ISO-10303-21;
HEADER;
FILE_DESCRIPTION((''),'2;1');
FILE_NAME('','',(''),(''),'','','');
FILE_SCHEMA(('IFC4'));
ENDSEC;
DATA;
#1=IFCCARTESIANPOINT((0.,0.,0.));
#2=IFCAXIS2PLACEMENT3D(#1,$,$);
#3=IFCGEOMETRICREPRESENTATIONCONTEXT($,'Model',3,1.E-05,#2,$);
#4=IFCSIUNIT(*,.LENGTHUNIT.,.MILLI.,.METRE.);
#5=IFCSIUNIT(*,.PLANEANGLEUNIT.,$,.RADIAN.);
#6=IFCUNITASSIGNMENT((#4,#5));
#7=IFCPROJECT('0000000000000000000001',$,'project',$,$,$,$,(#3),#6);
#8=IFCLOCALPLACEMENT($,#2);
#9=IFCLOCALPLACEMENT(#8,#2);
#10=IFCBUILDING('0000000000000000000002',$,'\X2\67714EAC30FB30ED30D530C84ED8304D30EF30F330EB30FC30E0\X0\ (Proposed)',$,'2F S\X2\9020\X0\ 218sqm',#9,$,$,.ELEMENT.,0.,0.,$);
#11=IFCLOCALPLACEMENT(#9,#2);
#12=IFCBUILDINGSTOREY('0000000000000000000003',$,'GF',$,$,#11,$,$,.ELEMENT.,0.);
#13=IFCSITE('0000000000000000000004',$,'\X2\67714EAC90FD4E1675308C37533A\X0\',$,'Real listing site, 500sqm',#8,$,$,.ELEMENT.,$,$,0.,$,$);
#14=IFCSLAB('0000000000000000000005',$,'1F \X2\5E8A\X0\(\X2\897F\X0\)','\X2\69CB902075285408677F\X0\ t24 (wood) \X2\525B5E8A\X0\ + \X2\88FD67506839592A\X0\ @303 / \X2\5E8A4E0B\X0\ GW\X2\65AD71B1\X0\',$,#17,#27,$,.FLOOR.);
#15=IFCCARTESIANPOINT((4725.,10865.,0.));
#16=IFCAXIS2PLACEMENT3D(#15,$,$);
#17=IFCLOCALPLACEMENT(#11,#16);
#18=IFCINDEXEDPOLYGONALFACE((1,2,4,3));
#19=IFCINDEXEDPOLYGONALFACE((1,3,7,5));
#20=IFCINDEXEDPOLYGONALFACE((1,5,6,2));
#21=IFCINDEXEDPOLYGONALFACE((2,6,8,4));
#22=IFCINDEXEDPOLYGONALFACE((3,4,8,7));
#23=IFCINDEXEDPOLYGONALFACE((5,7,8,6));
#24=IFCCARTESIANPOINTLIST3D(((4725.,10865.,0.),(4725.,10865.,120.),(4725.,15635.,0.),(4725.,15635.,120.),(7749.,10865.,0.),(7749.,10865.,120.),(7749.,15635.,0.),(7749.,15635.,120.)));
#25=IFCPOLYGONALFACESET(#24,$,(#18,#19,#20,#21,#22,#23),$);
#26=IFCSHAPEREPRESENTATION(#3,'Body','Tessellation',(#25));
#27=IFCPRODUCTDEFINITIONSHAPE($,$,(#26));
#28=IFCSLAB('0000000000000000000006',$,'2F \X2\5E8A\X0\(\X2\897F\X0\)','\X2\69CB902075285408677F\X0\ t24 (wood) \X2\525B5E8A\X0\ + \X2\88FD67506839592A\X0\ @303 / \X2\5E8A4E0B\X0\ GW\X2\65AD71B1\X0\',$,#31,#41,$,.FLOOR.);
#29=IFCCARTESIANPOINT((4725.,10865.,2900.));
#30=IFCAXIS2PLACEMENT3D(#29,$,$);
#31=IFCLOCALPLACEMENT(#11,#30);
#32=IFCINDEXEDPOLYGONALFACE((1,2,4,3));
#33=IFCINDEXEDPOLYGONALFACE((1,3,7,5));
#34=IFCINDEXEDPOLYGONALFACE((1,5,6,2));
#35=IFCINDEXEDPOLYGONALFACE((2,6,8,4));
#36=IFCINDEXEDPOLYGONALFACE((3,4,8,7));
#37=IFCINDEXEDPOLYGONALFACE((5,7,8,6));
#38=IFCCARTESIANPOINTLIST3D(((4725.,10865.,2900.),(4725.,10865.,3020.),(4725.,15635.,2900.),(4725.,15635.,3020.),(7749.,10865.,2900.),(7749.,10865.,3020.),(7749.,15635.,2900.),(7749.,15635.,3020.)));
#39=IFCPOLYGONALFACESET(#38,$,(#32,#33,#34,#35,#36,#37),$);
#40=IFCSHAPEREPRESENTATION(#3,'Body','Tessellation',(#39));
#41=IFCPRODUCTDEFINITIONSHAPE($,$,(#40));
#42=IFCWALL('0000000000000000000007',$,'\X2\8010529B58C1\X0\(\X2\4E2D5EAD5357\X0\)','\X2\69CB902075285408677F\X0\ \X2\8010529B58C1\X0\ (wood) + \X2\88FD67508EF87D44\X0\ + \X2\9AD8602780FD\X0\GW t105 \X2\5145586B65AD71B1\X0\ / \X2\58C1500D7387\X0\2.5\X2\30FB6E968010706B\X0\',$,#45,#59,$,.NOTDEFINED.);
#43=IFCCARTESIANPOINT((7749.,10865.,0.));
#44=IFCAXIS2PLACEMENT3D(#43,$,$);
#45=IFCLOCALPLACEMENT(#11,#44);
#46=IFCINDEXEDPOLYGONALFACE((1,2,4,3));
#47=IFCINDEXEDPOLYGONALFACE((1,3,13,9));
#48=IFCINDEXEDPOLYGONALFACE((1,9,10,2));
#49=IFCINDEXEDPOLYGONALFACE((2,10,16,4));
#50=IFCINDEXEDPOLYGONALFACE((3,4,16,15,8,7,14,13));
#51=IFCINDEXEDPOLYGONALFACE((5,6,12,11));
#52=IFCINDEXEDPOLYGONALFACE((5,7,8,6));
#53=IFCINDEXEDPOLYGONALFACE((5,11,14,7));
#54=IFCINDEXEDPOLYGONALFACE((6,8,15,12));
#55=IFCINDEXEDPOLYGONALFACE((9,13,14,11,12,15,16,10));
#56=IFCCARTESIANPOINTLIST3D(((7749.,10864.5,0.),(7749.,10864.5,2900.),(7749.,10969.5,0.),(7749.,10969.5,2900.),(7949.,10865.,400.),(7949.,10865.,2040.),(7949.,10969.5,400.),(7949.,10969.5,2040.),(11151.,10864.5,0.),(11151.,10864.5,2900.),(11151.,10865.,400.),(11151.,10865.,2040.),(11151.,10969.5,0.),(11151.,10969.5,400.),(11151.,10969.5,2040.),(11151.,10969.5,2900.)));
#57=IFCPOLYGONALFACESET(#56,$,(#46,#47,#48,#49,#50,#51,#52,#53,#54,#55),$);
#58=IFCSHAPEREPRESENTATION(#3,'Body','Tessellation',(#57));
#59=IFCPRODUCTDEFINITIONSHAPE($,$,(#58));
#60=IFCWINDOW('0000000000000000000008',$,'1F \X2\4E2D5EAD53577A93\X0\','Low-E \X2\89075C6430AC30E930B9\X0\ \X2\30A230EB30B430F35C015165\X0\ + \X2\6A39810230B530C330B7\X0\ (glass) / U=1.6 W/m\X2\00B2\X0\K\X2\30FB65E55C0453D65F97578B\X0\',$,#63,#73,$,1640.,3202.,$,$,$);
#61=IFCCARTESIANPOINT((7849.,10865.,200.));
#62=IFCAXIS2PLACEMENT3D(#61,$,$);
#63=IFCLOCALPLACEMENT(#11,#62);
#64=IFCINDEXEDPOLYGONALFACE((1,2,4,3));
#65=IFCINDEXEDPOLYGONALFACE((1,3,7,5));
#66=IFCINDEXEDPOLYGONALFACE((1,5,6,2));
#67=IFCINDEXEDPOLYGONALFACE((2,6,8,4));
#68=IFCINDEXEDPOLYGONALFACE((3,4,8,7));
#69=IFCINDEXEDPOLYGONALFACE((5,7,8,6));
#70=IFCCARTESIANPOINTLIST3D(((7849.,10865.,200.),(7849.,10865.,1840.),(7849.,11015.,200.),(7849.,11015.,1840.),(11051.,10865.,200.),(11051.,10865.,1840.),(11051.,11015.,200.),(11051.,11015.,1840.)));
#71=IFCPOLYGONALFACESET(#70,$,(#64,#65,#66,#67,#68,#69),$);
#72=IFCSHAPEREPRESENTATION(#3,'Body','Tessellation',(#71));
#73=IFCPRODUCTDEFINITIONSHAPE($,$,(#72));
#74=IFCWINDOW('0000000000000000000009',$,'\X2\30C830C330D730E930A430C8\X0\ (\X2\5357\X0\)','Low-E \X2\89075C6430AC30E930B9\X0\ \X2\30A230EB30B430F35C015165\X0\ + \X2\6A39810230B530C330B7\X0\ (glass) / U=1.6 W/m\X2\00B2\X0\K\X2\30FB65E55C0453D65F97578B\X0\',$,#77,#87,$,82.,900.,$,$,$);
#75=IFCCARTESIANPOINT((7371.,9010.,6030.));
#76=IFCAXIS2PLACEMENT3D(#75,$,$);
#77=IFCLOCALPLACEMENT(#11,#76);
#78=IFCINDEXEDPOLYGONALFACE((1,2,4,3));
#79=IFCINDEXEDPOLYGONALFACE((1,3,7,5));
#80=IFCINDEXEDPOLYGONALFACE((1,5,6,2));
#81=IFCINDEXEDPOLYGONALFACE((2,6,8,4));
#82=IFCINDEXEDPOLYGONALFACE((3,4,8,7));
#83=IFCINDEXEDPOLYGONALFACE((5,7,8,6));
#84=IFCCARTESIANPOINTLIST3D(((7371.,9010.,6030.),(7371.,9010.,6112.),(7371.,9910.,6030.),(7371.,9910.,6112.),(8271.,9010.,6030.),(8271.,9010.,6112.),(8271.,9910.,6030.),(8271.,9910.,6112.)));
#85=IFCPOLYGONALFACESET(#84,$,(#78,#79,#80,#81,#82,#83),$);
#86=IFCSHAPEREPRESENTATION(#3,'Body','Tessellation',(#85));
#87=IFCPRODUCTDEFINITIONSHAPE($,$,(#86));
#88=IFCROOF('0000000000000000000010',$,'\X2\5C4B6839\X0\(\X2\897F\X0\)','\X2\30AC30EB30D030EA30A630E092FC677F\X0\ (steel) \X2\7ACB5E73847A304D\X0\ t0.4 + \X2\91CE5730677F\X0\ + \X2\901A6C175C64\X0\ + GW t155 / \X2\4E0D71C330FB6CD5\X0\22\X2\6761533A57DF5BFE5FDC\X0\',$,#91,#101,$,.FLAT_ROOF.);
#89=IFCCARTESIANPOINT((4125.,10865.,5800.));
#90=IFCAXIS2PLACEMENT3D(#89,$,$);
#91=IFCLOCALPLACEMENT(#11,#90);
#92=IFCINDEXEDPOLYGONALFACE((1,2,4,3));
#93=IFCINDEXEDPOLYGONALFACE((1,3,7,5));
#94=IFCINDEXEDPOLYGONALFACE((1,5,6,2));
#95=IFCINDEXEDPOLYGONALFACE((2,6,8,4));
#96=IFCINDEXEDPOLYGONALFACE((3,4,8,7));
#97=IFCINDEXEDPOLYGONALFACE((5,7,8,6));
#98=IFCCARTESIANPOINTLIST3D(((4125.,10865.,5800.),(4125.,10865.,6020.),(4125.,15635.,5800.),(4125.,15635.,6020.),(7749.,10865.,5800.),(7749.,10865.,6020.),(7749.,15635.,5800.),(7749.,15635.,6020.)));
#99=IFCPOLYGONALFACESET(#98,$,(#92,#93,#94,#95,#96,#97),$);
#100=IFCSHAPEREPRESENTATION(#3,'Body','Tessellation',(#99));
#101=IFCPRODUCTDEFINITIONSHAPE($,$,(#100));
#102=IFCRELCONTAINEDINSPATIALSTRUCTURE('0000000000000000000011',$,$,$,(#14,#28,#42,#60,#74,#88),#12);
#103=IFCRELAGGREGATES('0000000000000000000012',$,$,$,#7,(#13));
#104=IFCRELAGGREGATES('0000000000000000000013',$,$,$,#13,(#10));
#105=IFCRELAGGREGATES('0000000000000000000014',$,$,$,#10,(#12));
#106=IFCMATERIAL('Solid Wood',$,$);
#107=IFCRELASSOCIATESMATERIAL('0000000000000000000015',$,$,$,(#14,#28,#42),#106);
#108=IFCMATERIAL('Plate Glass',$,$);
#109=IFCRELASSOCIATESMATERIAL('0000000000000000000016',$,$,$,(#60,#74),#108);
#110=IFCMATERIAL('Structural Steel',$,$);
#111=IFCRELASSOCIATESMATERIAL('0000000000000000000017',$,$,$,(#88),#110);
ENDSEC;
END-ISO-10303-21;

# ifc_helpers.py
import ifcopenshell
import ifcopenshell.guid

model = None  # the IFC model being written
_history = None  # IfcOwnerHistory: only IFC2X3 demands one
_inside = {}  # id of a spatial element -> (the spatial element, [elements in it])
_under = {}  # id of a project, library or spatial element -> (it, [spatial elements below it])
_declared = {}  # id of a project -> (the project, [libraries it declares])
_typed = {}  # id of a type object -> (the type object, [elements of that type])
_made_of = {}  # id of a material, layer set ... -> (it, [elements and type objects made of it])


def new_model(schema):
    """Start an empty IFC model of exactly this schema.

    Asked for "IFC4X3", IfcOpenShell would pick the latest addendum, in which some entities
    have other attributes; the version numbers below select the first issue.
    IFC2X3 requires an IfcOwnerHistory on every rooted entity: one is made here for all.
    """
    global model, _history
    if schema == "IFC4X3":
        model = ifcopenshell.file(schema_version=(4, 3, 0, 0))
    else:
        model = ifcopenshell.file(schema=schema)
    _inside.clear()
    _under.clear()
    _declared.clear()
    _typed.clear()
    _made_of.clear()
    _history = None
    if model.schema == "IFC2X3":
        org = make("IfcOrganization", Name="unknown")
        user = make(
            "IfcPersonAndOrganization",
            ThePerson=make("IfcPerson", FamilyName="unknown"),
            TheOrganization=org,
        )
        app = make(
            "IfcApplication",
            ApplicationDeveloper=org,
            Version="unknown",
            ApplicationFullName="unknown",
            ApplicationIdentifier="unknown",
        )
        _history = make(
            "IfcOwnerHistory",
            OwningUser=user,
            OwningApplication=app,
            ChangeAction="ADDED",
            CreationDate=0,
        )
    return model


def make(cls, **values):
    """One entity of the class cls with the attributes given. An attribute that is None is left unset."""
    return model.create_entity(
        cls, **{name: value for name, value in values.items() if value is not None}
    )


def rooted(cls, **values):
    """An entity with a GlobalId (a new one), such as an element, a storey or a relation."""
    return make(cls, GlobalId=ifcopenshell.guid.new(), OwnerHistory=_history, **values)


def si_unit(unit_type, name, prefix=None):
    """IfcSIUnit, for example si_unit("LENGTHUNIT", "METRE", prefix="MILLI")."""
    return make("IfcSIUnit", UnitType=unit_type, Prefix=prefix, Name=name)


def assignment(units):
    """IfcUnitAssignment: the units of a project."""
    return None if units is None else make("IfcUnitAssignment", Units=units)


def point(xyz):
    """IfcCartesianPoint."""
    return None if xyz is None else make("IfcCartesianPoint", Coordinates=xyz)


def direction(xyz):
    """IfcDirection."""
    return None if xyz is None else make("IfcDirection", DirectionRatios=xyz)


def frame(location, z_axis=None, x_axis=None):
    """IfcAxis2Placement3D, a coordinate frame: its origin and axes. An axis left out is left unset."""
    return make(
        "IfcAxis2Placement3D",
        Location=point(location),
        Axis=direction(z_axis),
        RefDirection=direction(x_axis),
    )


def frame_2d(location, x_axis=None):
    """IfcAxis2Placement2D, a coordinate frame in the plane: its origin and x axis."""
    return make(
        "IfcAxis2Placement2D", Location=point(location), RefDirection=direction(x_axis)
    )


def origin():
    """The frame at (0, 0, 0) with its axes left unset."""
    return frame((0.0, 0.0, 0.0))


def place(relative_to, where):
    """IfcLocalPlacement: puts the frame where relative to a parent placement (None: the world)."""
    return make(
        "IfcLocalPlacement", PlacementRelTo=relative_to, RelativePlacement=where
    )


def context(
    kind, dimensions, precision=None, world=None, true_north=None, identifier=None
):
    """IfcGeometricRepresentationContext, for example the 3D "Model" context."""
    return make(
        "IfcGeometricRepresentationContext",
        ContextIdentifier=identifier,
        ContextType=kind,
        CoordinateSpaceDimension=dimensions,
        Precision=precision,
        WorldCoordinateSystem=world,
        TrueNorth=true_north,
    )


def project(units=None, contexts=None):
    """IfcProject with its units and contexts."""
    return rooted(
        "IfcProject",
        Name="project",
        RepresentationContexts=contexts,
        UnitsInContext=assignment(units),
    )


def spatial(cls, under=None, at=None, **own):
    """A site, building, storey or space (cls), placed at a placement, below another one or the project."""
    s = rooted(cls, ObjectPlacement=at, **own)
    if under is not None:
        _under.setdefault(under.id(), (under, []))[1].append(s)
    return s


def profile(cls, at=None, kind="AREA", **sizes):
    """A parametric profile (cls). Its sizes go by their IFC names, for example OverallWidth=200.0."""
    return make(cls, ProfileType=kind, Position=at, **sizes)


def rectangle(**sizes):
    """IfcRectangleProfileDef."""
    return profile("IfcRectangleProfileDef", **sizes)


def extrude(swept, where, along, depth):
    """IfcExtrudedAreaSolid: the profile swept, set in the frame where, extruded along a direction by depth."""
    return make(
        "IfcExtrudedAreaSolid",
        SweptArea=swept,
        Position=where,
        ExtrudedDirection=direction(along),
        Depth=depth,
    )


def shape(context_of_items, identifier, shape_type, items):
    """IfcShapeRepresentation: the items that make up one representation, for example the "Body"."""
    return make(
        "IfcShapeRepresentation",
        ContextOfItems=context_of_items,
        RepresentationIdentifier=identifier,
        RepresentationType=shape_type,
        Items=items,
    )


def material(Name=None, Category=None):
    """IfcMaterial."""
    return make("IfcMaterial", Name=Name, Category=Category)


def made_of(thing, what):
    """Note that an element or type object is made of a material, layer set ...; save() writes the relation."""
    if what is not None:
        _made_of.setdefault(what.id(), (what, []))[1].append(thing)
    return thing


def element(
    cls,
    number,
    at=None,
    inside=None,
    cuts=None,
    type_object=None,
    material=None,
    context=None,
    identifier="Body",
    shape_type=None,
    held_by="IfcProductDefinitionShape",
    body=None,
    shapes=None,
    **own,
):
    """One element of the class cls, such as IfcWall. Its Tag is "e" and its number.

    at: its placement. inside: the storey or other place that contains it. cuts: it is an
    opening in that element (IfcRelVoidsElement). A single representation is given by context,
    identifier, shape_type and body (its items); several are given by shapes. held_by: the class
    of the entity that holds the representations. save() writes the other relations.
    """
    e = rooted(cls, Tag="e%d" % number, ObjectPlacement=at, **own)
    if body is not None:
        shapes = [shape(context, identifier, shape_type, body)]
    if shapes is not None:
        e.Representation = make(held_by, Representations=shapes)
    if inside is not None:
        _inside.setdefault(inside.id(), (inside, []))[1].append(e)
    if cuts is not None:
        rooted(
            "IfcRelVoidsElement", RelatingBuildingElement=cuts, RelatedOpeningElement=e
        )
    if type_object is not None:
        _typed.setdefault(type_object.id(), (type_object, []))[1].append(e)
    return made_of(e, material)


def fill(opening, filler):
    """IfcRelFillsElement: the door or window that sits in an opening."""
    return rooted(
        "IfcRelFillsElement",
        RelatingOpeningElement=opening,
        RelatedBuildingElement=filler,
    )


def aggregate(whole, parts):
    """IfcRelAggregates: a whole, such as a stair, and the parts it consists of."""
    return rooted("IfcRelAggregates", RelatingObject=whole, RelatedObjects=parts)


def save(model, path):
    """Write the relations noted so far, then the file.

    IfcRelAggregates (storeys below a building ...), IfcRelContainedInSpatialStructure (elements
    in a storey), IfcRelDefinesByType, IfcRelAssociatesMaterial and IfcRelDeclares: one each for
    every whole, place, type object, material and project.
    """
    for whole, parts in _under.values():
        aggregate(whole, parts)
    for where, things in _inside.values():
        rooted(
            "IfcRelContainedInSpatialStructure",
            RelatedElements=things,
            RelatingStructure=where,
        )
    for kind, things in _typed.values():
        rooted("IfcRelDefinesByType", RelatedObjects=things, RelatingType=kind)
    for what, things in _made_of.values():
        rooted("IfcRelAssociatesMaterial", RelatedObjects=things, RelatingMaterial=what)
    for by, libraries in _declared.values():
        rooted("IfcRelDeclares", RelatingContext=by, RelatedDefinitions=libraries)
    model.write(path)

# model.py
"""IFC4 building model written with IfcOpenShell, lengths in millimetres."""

from ifc_helpers import new_model, si_unit, frame, frame_2d, origin, place, context, project, spatial, rectangle, extrude, material, element, fill, save


model = new_model("IFC4")

# Units and contexts
model_context = context("Model", 3, precision=1e-05, world=origin())
ifc_project = project(units=[si_unit("LENGTHUNIT", "METRE", prefix="MILLI"), si_unit("PLANEANGLEUNIT", "RADIAN")], contexts=[model_context])

# Site, building, storey
site_placement = place(None, origin())
site = spatial("IfcSite", under=ifc_project, at=site_placement, Name="東京都世田谷区", ObjectType="Real listing site, 500sqm", CompositionType="ELEMENT", RefElevation=0.0)
building_placement = place(site_placement, origin())
building = spatial("IfcBuilding", under=site, at=building_placement, Name="東京・ロフト付きワンルーム (Proposed)", ObjectType="2F S造 218sqm", CompositionType="ELEMENT", ElevationOfRefHeight=0.0, ElevationOfTerrain=0.0)
storey_placement = place(building_placement, origin())
storey = spatial("IfcBuildingStorey", under=building, at=storey_placement, Name="GF", CompositionType="ELEMENT", Elevation=0.0)

# Shared definitions
ifc_material_1 = material(Name="Solid Wood")

# Slabs
slab_1_placement = place(storey_placement, frame((4725.0, 10865.0, 0.0)))
element("IfcSlab", 1, at=slab_1_placement, inside=storey, material=ifc_material_1, Name="1F 床(西)", Description="構造用合板 t24 (wood) 剛床 + 製材根太 @303 / 床下 GW断熱", PredefinedType="FLOOR", context=model_context, shape_type="SweptSolid", body=[
    extrude(rectangle(XDim=3024.0, YDim=4770.0, at=frame_2d((1512.0, 2385.0))), frame((4725.0, 10865.0, 0.0)), (0.0, 0.0, 1.0), 120.0),
])
slab_2_placement = place(storey_placement, frame((4725.0, 10865.0, 2900.0)))
element("IfcSlab", 2, at=slab_2_placement, inside=storey, material=ifc_material_1, Name="2F 床(西)", Description="構造用合板 t24 (wood) 剛床 + 製材根太 @303 / 床下 GW断熱", PredefinedType="FLOOR", context=model_context, shape_type="SweptSolid", body=[
    extrude(rectangle(XDim=3024.0, YDim=4770.0, at=frame_2d((1512.0, 2385.0))), frame((4725.0, 10865.0, 2900.0)), (0.0, 0.0, 1.0), 120.0),
])

# Wall, opening, window
wall_placement = place(storey_placement, frame((7749.0, 10865.0, 0.0)))
wall = element("IfcWall", 3, at=wall_placement, inside=storey, material=ifc_material_1, Name="耐力壁(中庭南)", Description="構造用合板 耐力壁 (wood) + 製材軸組 + 高性能GW t105 充填断熱 / 壁倍率2.5・準耐火", PredefinedType="NOTDEFINED", context=model_context, shape_type="SweptSolid", body=[
    extrude(rectangle(XDim=3402.0, YDim=105.0, at=frame_2d((1701.0, 52.0))), frame((7749.0, 10865.0, 0.0)), (0.0, 0.0, 1.0), 2900.0),
])
opening_placement = place(storey_placement, frame((7849.0, 10865.0, 200.0)))
opening = element("IfcOpeningElement", 4, at=opening_placement, cuts=wall, PredefinedType="NOTDEFINED", context=model_context, shape_type="SweptSolid", body=[
    extrude(rectangle(XDim=3202.0, YDim=150.0, at=frame_2d((1601.0, 75.0))), frame((7849.0, 10865.0, 200.0)), (0.0, 0.0, 1.0), 1640.0),
])
ifc_material_2 = material(Name="Plate Glass")
window_1_placement = place(storey_placement, frame((7849.0, 10865.0, 200.0)))
window_1 = element("IfcWindow", 5, at=window_1_placement, inside=storey, material=ifc_material_2, Name="1F 中庭南窓", Description="Low-E 複層ガラス アルゴン封入 + 樹脂サッシ (glass) / U=1.6 W/m²K・日射取得型", OverallHeight=1640.0, OverallWidth=3202.0, context=model_context, shape_type="SweptSolid", body=[
    extrude(rectangle(XDim=3202.0, YDim=150.0, at=frame_2d((1601.0, 75.0))), frame((7849.0, 10865.0, 200.0)), (0.0, 0.0, 1.0), 1640.0),
])
fill(opening, window_1)

# Window
window_2_placement = place(storey_placement, frame((7371.0, 9010.0, 6030.0)))
element("IfcWindow", 6, at=window_2_placement, inside=storey, material=ifc_material_2, Name="トップライト (南)", Description="Low-E 複層ガラス アルゴン封入 + 樹脂サッシ (glass) / U=1.6 W/m²K・日射取得型", OverallHeight=82.0, OverallWidth=900.0, context=model_context, shape_type="SweptSolid", body=[
    extrude(rectangle(XDim=900.0, YDim=900.0, at=frame_2d((450.0, 450.0))), frame((7371.0, 9010.0, 6030.0)), (0.0, 0.0, 1.0), 82.0),
])

# Roof
ifc_material_3 = material(Name="Structural Steel")
for number, where, name in (
    (7, (4125.0, 10865.0, 5800.0), "屋根(西)"),
):
    element("IfcRoof", number, at=place(storey_placement, frame(where)), inside=storey, material=ifc_material_3, Name=name, Description="ガルバリウム鋼板 (steel) 立平葺き t0.4 + 野地板 + 通気層 + GW t155 / 不燃・法22条区域対応", PredefinedType="FLAT_ROOF", context=model_context, shape_type="SweptSolid", body=[
        extrude(rectangle(XDim=3624.0, YDim=4770.0, at=frame_2d((1812.0, 2385.0))), frame((4125.0, 10865.0, 5800.0)), (0.0, 0.0, 1.0), 220.0),
    ])

save(model, "model.ifc")
